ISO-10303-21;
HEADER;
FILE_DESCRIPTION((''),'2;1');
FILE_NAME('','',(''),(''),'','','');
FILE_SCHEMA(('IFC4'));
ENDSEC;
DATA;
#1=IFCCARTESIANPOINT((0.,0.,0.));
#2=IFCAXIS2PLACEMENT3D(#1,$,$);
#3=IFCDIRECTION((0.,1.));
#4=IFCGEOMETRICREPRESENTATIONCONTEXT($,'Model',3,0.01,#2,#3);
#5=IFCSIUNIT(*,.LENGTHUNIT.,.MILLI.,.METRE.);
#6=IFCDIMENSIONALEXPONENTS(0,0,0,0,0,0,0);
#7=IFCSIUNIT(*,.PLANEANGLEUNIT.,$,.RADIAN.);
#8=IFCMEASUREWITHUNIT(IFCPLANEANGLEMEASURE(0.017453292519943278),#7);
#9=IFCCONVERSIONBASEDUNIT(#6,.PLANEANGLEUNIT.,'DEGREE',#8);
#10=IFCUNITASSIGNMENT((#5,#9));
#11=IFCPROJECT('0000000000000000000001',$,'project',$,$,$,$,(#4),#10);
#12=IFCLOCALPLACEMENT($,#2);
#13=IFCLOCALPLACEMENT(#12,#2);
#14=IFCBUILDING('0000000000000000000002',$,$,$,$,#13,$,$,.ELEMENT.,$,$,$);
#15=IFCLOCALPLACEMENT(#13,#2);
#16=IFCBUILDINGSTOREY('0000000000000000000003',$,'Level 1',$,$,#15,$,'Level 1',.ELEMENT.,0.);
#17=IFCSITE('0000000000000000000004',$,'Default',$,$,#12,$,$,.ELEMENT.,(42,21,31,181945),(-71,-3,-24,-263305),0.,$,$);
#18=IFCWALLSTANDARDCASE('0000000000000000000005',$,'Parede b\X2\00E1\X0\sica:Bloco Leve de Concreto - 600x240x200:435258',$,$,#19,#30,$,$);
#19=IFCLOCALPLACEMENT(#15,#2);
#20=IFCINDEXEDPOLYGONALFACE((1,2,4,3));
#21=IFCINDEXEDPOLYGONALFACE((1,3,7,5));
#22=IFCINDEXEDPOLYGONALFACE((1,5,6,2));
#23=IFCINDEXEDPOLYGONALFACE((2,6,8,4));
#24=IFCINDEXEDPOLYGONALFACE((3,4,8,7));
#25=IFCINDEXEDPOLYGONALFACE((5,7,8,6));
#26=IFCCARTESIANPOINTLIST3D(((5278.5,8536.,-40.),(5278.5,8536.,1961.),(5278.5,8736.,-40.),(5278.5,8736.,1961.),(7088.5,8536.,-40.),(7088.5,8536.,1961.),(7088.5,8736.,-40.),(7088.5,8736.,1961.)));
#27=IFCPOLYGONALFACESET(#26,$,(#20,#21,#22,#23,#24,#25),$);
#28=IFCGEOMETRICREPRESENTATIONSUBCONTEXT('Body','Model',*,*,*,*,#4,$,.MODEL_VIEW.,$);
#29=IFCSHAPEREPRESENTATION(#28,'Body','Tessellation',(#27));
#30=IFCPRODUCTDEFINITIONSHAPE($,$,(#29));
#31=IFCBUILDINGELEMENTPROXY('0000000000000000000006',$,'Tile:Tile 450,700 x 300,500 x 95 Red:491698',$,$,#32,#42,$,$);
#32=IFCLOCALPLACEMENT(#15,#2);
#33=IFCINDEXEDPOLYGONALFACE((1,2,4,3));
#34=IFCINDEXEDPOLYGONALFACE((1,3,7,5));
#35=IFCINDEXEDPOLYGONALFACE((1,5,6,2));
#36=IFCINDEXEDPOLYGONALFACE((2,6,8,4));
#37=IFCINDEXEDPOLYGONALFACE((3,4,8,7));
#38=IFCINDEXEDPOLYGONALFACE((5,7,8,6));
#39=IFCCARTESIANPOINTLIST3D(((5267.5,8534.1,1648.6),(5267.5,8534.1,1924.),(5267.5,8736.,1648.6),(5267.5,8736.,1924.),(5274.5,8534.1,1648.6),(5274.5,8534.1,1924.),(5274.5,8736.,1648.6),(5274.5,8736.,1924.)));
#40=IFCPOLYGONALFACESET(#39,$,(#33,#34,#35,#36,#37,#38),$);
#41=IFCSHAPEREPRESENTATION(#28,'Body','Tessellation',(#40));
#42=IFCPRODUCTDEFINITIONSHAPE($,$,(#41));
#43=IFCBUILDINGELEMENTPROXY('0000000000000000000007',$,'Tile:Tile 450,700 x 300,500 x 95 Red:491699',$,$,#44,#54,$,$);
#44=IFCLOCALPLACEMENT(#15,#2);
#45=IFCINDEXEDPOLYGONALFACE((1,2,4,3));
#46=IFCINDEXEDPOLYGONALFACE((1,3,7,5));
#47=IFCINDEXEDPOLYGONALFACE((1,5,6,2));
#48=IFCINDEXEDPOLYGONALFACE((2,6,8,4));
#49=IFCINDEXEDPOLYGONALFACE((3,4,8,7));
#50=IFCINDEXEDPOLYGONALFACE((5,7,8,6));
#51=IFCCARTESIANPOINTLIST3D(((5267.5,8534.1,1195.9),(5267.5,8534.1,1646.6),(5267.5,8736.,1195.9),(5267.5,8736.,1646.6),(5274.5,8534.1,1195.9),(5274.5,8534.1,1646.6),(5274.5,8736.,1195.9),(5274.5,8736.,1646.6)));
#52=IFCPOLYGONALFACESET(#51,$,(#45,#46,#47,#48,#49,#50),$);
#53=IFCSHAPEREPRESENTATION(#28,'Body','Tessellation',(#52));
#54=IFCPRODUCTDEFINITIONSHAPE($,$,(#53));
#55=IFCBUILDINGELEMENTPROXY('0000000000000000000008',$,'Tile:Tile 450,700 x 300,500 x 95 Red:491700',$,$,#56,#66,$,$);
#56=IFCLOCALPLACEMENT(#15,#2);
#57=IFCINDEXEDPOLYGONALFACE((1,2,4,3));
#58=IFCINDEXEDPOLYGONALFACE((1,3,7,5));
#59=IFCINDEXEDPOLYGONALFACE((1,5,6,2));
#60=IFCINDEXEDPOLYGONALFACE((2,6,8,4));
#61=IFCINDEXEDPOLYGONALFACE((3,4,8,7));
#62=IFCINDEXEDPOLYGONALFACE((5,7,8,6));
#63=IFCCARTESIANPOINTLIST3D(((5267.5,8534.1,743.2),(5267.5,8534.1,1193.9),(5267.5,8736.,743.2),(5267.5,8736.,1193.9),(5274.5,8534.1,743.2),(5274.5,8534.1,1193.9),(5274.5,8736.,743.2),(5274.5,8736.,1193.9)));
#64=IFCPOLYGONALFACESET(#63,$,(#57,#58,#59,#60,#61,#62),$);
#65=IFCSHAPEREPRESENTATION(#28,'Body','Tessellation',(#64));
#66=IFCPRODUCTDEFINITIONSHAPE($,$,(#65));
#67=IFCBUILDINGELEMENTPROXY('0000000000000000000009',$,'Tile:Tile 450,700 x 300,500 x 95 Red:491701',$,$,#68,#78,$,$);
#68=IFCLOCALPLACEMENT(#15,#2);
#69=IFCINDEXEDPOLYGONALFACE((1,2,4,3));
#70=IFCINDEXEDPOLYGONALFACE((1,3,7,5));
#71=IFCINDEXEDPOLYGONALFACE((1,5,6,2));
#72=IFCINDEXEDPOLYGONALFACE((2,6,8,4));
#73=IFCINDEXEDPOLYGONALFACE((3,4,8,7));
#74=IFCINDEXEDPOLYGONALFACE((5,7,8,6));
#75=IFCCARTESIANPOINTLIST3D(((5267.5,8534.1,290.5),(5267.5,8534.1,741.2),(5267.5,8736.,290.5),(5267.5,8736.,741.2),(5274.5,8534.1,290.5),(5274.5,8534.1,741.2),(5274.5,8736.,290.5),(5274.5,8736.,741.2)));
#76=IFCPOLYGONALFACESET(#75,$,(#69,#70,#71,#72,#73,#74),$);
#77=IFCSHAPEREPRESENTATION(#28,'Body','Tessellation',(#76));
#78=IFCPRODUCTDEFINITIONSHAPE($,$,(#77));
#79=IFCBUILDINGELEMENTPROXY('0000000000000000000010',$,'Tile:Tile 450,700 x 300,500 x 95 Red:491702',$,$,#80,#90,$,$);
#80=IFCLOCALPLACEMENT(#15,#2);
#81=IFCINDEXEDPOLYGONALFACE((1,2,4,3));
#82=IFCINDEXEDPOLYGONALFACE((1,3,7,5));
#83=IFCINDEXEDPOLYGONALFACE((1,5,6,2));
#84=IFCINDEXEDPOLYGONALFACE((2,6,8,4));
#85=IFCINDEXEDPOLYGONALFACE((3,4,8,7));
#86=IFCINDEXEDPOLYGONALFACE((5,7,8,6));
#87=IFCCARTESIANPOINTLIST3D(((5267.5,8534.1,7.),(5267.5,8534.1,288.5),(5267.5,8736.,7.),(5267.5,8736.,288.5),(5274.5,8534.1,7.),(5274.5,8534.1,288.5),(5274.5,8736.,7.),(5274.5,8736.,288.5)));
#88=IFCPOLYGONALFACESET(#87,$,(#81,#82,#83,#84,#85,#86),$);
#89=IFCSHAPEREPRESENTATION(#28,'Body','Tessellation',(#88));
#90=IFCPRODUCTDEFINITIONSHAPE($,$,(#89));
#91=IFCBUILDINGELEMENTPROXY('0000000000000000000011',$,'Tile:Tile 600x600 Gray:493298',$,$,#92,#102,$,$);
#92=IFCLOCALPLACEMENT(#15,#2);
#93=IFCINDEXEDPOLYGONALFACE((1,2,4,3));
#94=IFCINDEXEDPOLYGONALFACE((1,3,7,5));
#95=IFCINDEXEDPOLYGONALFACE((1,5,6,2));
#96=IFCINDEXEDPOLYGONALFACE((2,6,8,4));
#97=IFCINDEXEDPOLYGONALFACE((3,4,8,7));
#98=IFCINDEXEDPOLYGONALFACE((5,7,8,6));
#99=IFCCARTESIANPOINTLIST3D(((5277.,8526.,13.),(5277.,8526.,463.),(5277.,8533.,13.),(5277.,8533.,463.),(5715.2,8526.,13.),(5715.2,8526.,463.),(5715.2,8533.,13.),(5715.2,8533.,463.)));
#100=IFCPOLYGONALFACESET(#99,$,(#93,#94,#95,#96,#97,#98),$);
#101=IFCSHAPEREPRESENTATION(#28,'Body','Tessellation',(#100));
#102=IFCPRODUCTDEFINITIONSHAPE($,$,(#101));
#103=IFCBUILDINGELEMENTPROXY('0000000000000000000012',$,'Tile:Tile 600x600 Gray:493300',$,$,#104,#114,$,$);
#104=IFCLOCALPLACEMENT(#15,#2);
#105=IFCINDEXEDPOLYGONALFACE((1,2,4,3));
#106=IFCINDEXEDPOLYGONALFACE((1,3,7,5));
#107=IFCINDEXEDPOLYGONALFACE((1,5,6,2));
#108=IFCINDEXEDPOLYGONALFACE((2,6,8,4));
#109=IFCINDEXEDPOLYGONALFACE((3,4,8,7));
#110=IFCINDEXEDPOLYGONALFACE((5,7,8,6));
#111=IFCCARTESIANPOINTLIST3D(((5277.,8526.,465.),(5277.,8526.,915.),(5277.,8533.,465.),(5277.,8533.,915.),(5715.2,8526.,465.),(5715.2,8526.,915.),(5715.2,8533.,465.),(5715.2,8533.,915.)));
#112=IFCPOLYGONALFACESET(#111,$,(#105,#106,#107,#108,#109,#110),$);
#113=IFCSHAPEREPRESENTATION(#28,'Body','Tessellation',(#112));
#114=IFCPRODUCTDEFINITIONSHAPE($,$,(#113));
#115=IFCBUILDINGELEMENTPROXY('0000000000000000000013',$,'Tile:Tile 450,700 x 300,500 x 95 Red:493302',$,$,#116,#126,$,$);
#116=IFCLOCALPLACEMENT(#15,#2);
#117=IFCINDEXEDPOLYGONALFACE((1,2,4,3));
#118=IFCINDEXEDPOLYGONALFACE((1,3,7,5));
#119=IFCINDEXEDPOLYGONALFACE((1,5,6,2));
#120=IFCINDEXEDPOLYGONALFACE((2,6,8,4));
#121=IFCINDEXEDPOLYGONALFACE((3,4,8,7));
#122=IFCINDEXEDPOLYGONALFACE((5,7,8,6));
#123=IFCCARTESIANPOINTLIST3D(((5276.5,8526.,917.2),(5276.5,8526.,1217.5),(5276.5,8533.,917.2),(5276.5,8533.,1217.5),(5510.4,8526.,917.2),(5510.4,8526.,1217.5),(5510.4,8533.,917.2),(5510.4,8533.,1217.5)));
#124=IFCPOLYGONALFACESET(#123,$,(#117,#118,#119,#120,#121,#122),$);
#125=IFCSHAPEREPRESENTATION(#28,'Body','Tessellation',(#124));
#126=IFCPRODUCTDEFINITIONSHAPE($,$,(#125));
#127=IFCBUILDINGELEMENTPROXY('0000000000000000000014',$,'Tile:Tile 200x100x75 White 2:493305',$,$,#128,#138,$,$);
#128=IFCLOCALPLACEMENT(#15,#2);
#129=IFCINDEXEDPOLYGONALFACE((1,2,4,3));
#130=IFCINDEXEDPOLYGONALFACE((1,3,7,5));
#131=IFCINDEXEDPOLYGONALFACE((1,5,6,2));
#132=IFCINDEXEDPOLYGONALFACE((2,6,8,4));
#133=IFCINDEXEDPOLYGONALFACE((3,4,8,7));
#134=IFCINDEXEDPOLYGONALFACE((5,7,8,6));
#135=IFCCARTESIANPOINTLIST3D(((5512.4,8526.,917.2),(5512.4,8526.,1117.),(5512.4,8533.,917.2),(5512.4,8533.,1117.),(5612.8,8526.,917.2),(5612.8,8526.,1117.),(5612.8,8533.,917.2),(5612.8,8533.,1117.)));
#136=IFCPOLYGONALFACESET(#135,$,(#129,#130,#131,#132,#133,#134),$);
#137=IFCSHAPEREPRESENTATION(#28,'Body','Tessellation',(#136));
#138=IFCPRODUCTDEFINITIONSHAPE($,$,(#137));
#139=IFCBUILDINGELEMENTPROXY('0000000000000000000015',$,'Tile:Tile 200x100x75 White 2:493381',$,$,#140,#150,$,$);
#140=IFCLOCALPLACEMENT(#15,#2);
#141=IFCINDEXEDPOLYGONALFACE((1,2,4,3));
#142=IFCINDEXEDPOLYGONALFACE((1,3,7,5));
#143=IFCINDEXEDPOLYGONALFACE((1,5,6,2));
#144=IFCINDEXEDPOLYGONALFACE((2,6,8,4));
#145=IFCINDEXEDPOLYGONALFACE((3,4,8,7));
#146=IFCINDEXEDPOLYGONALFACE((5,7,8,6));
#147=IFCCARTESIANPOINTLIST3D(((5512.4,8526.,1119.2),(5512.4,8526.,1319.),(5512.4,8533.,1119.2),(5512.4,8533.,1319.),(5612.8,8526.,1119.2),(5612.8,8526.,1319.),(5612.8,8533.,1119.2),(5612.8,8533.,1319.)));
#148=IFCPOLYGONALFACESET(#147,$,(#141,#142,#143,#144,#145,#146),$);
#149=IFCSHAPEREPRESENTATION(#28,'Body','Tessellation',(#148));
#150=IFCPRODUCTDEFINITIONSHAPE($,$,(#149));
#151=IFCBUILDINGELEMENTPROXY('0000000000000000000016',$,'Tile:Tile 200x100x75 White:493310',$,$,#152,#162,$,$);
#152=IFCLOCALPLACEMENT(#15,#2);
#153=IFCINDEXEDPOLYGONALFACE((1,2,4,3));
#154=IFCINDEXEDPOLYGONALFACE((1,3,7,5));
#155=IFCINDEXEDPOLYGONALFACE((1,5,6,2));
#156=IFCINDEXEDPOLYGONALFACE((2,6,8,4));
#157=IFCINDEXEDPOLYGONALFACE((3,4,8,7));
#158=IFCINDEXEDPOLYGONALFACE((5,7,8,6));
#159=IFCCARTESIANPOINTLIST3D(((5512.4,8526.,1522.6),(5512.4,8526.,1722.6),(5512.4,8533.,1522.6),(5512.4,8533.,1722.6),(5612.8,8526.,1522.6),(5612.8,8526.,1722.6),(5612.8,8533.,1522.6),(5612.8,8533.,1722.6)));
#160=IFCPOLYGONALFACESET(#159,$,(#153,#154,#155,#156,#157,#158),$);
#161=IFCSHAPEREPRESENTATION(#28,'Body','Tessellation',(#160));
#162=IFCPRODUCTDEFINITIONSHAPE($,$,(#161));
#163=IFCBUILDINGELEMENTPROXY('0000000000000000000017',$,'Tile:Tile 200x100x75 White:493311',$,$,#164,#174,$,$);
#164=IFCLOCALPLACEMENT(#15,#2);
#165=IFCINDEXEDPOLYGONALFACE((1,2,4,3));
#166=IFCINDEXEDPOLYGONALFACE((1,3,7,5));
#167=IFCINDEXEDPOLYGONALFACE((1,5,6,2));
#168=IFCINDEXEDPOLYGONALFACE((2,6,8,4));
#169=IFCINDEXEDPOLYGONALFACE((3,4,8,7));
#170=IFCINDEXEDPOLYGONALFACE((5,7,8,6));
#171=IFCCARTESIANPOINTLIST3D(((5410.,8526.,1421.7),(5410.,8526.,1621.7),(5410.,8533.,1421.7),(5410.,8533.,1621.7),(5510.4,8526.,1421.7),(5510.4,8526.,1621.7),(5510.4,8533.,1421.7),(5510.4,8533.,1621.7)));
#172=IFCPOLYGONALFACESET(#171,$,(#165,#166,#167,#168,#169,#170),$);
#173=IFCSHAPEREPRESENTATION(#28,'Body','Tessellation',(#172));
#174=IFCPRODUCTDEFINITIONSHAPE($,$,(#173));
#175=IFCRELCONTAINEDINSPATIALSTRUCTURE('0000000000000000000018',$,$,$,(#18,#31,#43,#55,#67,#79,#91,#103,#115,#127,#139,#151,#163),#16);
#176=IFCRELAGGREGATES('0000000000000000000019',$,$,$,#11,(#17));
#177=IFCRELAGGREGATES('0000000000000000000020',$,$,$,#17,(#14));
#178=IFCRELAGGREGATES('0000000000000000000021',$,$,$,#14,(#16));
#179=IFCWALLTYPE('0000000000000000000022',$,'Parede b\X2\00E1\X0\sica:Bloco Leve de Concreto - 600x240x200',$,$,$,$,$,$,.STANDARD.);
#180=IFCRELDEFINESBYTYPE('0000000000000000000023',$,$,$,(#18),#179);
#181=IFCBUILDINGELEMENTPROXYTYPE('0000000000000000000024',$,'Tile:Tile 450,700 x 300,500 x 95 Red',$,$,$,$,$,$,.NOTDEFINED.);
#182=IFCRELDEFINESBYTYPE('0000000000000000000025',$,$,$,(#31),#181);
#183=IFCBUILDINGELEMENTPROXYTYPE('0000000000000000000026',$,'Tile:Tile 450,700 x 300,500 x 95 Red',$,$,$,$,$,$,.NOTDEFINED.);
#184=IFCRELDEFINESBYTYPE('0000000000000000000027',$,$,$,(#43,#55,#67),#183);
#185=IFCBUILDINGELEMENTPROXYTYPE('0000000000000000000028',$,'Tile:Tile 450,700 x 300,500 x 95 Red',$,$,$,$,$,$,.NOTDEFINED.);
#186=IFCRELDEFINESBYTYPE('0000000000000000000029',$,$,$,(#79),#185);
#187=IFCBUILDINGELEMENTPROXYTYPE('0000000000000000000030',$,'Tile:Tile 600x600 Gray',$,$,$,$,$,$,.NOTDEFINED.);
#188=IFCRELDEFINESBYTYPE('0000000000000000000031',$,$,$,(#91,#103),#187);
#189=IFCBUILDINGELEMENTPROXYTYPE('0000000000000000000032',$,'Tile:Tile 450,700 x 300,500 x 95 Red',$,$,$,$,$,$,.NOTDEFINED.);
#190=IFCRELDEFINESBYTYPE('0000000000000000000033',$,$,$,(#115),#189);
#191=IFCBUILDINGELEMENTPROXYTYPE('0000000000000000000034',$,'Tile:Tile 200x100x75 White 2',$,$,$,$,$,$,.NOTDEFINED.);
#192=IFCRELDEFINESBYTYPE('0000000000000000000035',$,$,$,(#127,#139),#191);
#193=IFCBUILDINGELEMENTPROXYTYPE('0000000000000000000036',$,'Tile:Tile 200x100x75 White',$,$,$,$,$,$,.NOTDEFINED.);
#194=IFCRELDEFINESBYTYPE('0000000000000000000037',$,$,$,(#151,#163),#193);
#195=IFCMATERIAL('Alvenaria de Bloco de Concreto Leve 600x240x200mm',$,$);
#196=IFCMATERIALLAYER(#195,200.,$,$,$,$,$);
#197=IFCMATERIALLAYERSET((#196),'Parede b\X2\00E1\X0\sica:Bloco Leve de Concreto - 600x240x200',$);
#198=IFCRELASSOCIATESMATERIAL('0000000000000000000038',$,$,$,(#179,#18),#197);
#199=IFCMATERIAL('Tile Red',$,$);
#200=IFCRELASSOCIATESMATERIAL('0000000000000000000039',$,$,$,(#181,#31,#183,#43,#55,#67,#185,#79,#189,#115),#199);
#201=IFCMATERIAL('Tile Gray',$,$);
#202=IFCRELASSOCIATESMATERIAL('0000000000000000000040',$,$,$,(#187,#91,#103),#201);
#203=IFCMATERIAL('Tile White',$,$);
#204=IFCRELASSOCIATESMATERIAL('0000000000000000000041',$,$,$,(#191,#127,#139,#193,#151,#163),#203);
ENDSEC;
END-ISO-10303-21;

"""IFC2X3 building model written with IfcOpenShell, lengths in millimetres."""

from ifc_helpers import new_model, entity, si_unit, converted_unit, direction, frame, frame_2d, origin, origin_2d_with_axis, place, context, subcontext, project, spatial, rectangle, extrude, source, transform, mapped, material, layer, layer_set, layer_usage, type_object, type_shapes, element, save


model = new_model("IFC2X3")

# Units and contexts
model_context = context("Model", 3, precision=0.01, world=origin(), true_north=direction((0.0, 1.0)))
body_context = subcontext(model_context, "Body", "Model", "MODEL_VIEW")
ifc_project = project(units=[si_unit("LENGTHUNIT", "METRE", prefix="MILLI"), converted_unit("PLANEANGLEUNIT", "DEGREE", entity("IfcPlaneAngleMeasure", 0.017453292519943278), si_unit("PLANEANGLEUNIT", "RADIAN"), dimensions=[0, 0, 0, 0, 0, 0, 0])], contexts=[model_context])

# Site, building, storey
site_placement = place(None, origin())
site = spatial("IfcSite", under=ifc_project, at=site_placement, Name="Default", CompositionType="ELEMENT", RefLatitude=(42, 21, 31, 181945), RefLongitude=(-71, -3, -24, -263305), RefElevation=0.0)
building_placement = place(site_placement, origin())
building = spatial("IfcBuilding", under=site, at=building_placement, CompositionType="ELEMENT")
storey_placement = place(building_placement, origin())
storey = spatial("IfcBuildingStorey", under=building, at=storey_placement, Name="Level 1", LongName="Level 1", CompositionType="ELEMENT", Elevation=0.0)

# Wall
ifc_material_1 = material(Name="Alvenaria de Bloco de Concreto Leve 600x240x200mm")
ifc_layer = layer(ifc_material_1, 200.0)
ifc_layer_set = layer_set([ifc_layer], Name="Parede básica:Bloco Leve de Concreto - 600x240x200")
ifc_layer_usage = layer_usage(ifc_layer_set, "AXIS2", "NEGATIVE", 100.0)
wall_type = type_object("IfcWallType", Name="Parede básica:Bloco Leve de Concreto - 600x240x200", PredefinedType="STANDARD", material=ifc_layer_set)
wall_placement = place(storey_placement, frame((5278.5, 8636.0, -40.0)))
element("IfcWallStandardCase", 1, at=wall_placement, inside=storey, type_object=wall_type, material=ifc_layer_usage, Name="Parede básica:Bloco Leve de Concreto - 600x240x200:435258", context=body_context, shape_type="SweptSolid", body=[
    extrude(rectangle(XDim=1810.0, YDim=200.0, at=frame_2d((905.0, 0.0), x_axis=(-1.0, 0.0))), origin(), (0.0, 0.0, 1.0), 2001.0),
])

# Building element proxies
ifc_material_2 = material(Name="Tile Red")
building_element_proxy_type_1 = type_object("IfcBuildingElementProxyType", Name="Tile:Tile 450,700 x 300,500 x 95 Red", PredefinedType="NOTDEFINED", material=ifc_material_2)
shared_shape_1 = source(origin(), body_context, "Body", "SweptSolid", [
    extrude(rectangle(XDim=202.0, YDim=275.4, at=frame_2d((0.0, 0.0), x_axis=(1.0, 0.0))), frame((-101.0, -137.7, 0.0), z_axis=(0.0, 0.0, 1.0), x_axis=(-1.0, 0.0, 0.0)), (0.0, 0.0, 1.0), 7.0),
])
type_shapes(building_element_proxy_type_1, [shared_shape_1])
proxy_1_placement = place(storey_placement, frame((5274.5, 8736.0, 1648.6), z_axis=(-1.0, 0.0, 0.0), x_axis=(0.0, 1.0, 0.0)))
element("IfcBuildingElementProxy", 2, at=proxy_1_placement, inside=storey, type_object=building_element_proxy_type_1, material=ifc_material_2, Name="Tile:Tile 450,700 x 300,500 x 95 Red:491698", context=body_context, shape_type="MappedRepresentation", body=[
    mapped(shared_shape_1, transform((0.0, 0.0, 0.0), scale=1.0)),
])
building_element_proxy_type_2 = type_object("IfcBuildingElementProxyType", Name="Tile:Tile 450,700 x 300,500 x 95 Red", PredefinedType="NOTDEFINED", material=ifc_material_2)
shared_shape_2 = source(origin(), body_context, "Body", "SweptSolid", [
    extrude(rectangle(XDim=202.0, YDim=450.7, at=frame_2d((0.0, 0.0), x_axis=(1.0, 0.0))), frame((-101.0, -225.4, 0.0), z_axis=(0.0, 0.0, 1.0), x_axis=(-1.0, 0.0, 0.0)), (0.0, 0.0, 1.0), 7.0),
])
type_shapes(building_element_proxy_type_2, [shared_shape_2])
for number, where, z_axis, x_axis, name in (
    (3, (5274.5, 8736.0, 1195.9), (-1.0, 0.0, 0.0), (0.0, 1.0, 0.0), "Tile:Tile 450,700 x 300,500 x 95 Red:491699"),
    (4, (5274.5, 8736.0, 743.2), (-1.0, 0.0, 0.0), (0.0, 1.0, 0.0), "Tile:Tile 450,700 x 300,500 x 95 Red:491700"),
    (5, (5274.5, 8736.0, 290.5), (-1.0, 0.0, 0.0), (0.0, 1.0, 0.0), "Tile:Tile 450,700 x 300,500 x 95 Red:491701"),
):
    element("IfcBuildingElementProxy", number, at=place(storey_placement, frame(where, z_axis=z_axis, x_axis=x_axis)), inside=storey, type_object=building_element_proxy_type_2, material=ifc_material_2, Name=name, context=body_context, shape_type="MappedRepresentation", body=[
        mapped(shared_shape_2, transform((0.0, 0.0, 0.0), scale=1.0)),
    ])
building_element_proxy_type_3 = type_object("IfcBuildingElementProxyType", Name="Tile:Tile 450,700 x 300,500 x 95 Red", PredefinedType="NOTDEFINED", material=ifc_material_2)
shared_shape_3 = source(origin(), body_context, "Body", "SweptSolid", [
    extrude(rectangle(XDim=202.0, YDim=281.4, at=frame_2d((0.0, 0.0), x_axis=(1.0, 0.0))), frame((-101.0, -140.7, 0.0), z_axis=(0.0, 0.0, 1.0), x_axis=(-1.0, 0.0, 0.0)), (0.0, 0.0, 1.0), 7.0),
])
type_shapes(building_element_proxy_type_3, [shared_shape_3])
proxy_2_placement = place(storey_placement, frame((5274.5, 8736.0, 7.0), z_axis=(-1.0, 0.0, 0.0), x_axis=(0.0, 1.0, 0.0)))
element("IfcBuildingElementProxy", 6, at=proxy_2_placement, inside=storey, type_object=building_element_proxy_type_3, material=ifc_material_2, Name="Tile:Tile 450,700 x 300,500 x 95 Red:491702", context=body_context, shape_type="MappedRepresentation", body=[
    mapped(shared_shape_3, transform((0.0, 0.0, 0.0), scale=1.0)),
])
ifc_material_3 = material(Name="Tile Gray")
building_element_proxy_type_4 = type_object("IfcBuildingElementProxyType", Name="Tile:Tile 600x600 Gray", PredefinedType="NOTDEFINED", material=ifc_material_3)
shared_shape_4 = source(origin(), body_context, "Body", "SweptSolid", [
    extrude(rectangle(XDim=438.2, YDim=450.0, at=origin_2d_with_axis()), frame((-219.1, -225.0, 0.0), z_axis=(0.0, 0.0, 1.0), x_axis=(-1.0, 0.0, 0.0)), (0.0, 0.0, 1.0), 7.0),
])
type_shapes(building_element_proxy_type_4, [shared_shape_4])
for number, where, z_axis, x_axis, name in (
    (7, (5715.2, 8533.0, 463.0), (0.0, -1.0, 0.0), (1.0, 0.0, 0.0), "Tile:Tile 600x600 Gray:493298"),
    (8, (5715.2, 8533.0, 915.0), (0.0, -1.0, 0.0), (1.0, 0.0, 0.0), "Tile:Tile 600x600 Gray:493300"),
):
    element("IfcBuildingElementProxy", number, at=place(storey_placement, frame(where, z_axis=z_axis, x_axis=x_axis)), inside=storey, type_object=building_element_proxy_type_4, material=ifc_material_3, Name=name, context=body_context, shape_type="MappedRepresentation", body=[
        mapped(shared_shape_4, transform((0.0, 0.0, 0.0), scale=1.0)),
    ])
building_element_proxy_type_5 = type_object("IfcBuildingElementProxyType", Name="Tile:Tile 450,700 x 300,500 x 95 Red", PredefinedType="NOTDEFINED", material=ifc_material_2)
shared_shape_5 = source(origin(), body_context, "Body", "SweptSolid", [
    extrude(rectangle(XDim=233.9, YDim=300.3, at=frame_2d((0.0, 0.0), x_axis=(1.0, 0.0))), frame((-116.9, -150.2, 0.0), z_axis=(0.0, 0.0, 1.0), x_axis=(-1.0, 0.0, 0.0)), (0.0, 0.0, 1.0), 7.0),
])
type_shapes(building_element_proxy_type_5, [shared_shape_5])
proxy_3_placement = place(storey_placement, frame((5510.4, 8533.0, 1217.5), z_axis=(0.0, -1.0, 0.0), x_axis=(1.0, 0.0, 0.0)))
element("IfcBuildingElementProxy", 9, at=proxy_3_placement, inside=storey, type_object=building_element_proxy_type_5, material=ifc_material_2, Name="Tile:Tile 450,700 x 300,500 x 95 Red:493302", context=body_context, shape_type="MappedRepresentation", body=[
    mapped(shared_shape_5, transform((0.0, 0.0, 0.0), scale=1.0)),
])
ifc_material_4 = material(Name="Tile White")
building_element_proxy_type_6 = type_object("IfcBuildingElementProxyType", Name="Tile:Tile 200x100x75 White 2", PredefinedType="NOTDEFINED", material=ifc_material_4)
shared_shape_6 = source(origin(), body_context, "Body", "SweptSolid", [
    extrude(rectangle(XDim=199.8, YDim=100.4, at=frame_2d((0.0, 0.0), x_axis=(1.0, 0.0))), frame((-50.2, -99.9, 0.0), z_axis=(0.0, 0.0, 1.0), x_axis=(0.0, -1.0, 0.0)), (0.0, 0.0, 1.0), 7.0),
])
type_shapes(building_element_proxy_type_6, [shared_shape_6])
for number, where, z_axis, x_axis, name in (
    (10, (5612.8, 8533.0, 1117.0), (0.0, -1.0, 0.0), (1.0, 0.0, 0.0), "Tile:Tile 200x100x75 White 2:493305"),
    (11, (5612.8, 8533.0, 1319.0), (0.0, -1.0, 0.0), (1.0, 0.0, 0.0), "Tile:Tile 200x100x75 White 2:493381"),
):
    element("IfcBuildingElementProxy", number, at=place(storey_placement, frame(where, z_axis=z_axis, x_axis=x_axis)), inside=storey, type_object=building_element_proxy_type_6, material=ifc_material_4, Name=name, context=body_context, shape_type="MappedRepresentation", body=[
        mapped(shared_shape_6, transform((0.0, 0.0, 0.0), scale=1.0)),
    ])
building_element_proxy_type_7 = type_object("IfcBuildingElementProxyType", Name="Tile:Tile 200x100x75 White", PredefinedType="NOTDEFINED", material=ifc_material_4)
shared_shape_7 = source(origin(), body_context, "Body", "SweptSolid", [
    extrude(rectangle(XDim=200.0, YDim=100.4, at=frame_2d((0.0, 0.0), x_axis=(1.0, 0.0))), frame((-50.2, -100.0, 0.0), z_axis=(0.0, 0.0, 1.0), x_axis=(0.0, -1.0, 0.0)), (0.0, 0.0, 1.0), 7.0),
])
type_shapes(building_element_proxy_type_7, [shared_shape_7])
for number, where, z_axis, x_axis, name in (
    (12, (5612.8, 8533.0, 1722.6), (0.0, -1.0, 0.0), (1.0, 0.0, 0.0), "Tile:Tile 200x100x75 White:493310"),
    (13, (5510.4, 8533.0, 1621.7), (0.0, -1.0, 0.0), (1.0, 0.0, 0.0), "Tile:Tile 200x100x75 White:493311"),
):
    element("IfcBuildingElementProxy", number, at=place(storey_placement, frame(where, z_axis=z_axis, x_axis=x_axis)), inside=storey, type_object=building_element_proxy_type_7, material=ifc_material_4, Name=name, context=body_context, shape_type="MappedRepresentation", body=[
        mapped(shared_shape_7, transform((0.0, 0.0, 0.0), scale=1.0)),
    ])

save(model, "model.ifc")
